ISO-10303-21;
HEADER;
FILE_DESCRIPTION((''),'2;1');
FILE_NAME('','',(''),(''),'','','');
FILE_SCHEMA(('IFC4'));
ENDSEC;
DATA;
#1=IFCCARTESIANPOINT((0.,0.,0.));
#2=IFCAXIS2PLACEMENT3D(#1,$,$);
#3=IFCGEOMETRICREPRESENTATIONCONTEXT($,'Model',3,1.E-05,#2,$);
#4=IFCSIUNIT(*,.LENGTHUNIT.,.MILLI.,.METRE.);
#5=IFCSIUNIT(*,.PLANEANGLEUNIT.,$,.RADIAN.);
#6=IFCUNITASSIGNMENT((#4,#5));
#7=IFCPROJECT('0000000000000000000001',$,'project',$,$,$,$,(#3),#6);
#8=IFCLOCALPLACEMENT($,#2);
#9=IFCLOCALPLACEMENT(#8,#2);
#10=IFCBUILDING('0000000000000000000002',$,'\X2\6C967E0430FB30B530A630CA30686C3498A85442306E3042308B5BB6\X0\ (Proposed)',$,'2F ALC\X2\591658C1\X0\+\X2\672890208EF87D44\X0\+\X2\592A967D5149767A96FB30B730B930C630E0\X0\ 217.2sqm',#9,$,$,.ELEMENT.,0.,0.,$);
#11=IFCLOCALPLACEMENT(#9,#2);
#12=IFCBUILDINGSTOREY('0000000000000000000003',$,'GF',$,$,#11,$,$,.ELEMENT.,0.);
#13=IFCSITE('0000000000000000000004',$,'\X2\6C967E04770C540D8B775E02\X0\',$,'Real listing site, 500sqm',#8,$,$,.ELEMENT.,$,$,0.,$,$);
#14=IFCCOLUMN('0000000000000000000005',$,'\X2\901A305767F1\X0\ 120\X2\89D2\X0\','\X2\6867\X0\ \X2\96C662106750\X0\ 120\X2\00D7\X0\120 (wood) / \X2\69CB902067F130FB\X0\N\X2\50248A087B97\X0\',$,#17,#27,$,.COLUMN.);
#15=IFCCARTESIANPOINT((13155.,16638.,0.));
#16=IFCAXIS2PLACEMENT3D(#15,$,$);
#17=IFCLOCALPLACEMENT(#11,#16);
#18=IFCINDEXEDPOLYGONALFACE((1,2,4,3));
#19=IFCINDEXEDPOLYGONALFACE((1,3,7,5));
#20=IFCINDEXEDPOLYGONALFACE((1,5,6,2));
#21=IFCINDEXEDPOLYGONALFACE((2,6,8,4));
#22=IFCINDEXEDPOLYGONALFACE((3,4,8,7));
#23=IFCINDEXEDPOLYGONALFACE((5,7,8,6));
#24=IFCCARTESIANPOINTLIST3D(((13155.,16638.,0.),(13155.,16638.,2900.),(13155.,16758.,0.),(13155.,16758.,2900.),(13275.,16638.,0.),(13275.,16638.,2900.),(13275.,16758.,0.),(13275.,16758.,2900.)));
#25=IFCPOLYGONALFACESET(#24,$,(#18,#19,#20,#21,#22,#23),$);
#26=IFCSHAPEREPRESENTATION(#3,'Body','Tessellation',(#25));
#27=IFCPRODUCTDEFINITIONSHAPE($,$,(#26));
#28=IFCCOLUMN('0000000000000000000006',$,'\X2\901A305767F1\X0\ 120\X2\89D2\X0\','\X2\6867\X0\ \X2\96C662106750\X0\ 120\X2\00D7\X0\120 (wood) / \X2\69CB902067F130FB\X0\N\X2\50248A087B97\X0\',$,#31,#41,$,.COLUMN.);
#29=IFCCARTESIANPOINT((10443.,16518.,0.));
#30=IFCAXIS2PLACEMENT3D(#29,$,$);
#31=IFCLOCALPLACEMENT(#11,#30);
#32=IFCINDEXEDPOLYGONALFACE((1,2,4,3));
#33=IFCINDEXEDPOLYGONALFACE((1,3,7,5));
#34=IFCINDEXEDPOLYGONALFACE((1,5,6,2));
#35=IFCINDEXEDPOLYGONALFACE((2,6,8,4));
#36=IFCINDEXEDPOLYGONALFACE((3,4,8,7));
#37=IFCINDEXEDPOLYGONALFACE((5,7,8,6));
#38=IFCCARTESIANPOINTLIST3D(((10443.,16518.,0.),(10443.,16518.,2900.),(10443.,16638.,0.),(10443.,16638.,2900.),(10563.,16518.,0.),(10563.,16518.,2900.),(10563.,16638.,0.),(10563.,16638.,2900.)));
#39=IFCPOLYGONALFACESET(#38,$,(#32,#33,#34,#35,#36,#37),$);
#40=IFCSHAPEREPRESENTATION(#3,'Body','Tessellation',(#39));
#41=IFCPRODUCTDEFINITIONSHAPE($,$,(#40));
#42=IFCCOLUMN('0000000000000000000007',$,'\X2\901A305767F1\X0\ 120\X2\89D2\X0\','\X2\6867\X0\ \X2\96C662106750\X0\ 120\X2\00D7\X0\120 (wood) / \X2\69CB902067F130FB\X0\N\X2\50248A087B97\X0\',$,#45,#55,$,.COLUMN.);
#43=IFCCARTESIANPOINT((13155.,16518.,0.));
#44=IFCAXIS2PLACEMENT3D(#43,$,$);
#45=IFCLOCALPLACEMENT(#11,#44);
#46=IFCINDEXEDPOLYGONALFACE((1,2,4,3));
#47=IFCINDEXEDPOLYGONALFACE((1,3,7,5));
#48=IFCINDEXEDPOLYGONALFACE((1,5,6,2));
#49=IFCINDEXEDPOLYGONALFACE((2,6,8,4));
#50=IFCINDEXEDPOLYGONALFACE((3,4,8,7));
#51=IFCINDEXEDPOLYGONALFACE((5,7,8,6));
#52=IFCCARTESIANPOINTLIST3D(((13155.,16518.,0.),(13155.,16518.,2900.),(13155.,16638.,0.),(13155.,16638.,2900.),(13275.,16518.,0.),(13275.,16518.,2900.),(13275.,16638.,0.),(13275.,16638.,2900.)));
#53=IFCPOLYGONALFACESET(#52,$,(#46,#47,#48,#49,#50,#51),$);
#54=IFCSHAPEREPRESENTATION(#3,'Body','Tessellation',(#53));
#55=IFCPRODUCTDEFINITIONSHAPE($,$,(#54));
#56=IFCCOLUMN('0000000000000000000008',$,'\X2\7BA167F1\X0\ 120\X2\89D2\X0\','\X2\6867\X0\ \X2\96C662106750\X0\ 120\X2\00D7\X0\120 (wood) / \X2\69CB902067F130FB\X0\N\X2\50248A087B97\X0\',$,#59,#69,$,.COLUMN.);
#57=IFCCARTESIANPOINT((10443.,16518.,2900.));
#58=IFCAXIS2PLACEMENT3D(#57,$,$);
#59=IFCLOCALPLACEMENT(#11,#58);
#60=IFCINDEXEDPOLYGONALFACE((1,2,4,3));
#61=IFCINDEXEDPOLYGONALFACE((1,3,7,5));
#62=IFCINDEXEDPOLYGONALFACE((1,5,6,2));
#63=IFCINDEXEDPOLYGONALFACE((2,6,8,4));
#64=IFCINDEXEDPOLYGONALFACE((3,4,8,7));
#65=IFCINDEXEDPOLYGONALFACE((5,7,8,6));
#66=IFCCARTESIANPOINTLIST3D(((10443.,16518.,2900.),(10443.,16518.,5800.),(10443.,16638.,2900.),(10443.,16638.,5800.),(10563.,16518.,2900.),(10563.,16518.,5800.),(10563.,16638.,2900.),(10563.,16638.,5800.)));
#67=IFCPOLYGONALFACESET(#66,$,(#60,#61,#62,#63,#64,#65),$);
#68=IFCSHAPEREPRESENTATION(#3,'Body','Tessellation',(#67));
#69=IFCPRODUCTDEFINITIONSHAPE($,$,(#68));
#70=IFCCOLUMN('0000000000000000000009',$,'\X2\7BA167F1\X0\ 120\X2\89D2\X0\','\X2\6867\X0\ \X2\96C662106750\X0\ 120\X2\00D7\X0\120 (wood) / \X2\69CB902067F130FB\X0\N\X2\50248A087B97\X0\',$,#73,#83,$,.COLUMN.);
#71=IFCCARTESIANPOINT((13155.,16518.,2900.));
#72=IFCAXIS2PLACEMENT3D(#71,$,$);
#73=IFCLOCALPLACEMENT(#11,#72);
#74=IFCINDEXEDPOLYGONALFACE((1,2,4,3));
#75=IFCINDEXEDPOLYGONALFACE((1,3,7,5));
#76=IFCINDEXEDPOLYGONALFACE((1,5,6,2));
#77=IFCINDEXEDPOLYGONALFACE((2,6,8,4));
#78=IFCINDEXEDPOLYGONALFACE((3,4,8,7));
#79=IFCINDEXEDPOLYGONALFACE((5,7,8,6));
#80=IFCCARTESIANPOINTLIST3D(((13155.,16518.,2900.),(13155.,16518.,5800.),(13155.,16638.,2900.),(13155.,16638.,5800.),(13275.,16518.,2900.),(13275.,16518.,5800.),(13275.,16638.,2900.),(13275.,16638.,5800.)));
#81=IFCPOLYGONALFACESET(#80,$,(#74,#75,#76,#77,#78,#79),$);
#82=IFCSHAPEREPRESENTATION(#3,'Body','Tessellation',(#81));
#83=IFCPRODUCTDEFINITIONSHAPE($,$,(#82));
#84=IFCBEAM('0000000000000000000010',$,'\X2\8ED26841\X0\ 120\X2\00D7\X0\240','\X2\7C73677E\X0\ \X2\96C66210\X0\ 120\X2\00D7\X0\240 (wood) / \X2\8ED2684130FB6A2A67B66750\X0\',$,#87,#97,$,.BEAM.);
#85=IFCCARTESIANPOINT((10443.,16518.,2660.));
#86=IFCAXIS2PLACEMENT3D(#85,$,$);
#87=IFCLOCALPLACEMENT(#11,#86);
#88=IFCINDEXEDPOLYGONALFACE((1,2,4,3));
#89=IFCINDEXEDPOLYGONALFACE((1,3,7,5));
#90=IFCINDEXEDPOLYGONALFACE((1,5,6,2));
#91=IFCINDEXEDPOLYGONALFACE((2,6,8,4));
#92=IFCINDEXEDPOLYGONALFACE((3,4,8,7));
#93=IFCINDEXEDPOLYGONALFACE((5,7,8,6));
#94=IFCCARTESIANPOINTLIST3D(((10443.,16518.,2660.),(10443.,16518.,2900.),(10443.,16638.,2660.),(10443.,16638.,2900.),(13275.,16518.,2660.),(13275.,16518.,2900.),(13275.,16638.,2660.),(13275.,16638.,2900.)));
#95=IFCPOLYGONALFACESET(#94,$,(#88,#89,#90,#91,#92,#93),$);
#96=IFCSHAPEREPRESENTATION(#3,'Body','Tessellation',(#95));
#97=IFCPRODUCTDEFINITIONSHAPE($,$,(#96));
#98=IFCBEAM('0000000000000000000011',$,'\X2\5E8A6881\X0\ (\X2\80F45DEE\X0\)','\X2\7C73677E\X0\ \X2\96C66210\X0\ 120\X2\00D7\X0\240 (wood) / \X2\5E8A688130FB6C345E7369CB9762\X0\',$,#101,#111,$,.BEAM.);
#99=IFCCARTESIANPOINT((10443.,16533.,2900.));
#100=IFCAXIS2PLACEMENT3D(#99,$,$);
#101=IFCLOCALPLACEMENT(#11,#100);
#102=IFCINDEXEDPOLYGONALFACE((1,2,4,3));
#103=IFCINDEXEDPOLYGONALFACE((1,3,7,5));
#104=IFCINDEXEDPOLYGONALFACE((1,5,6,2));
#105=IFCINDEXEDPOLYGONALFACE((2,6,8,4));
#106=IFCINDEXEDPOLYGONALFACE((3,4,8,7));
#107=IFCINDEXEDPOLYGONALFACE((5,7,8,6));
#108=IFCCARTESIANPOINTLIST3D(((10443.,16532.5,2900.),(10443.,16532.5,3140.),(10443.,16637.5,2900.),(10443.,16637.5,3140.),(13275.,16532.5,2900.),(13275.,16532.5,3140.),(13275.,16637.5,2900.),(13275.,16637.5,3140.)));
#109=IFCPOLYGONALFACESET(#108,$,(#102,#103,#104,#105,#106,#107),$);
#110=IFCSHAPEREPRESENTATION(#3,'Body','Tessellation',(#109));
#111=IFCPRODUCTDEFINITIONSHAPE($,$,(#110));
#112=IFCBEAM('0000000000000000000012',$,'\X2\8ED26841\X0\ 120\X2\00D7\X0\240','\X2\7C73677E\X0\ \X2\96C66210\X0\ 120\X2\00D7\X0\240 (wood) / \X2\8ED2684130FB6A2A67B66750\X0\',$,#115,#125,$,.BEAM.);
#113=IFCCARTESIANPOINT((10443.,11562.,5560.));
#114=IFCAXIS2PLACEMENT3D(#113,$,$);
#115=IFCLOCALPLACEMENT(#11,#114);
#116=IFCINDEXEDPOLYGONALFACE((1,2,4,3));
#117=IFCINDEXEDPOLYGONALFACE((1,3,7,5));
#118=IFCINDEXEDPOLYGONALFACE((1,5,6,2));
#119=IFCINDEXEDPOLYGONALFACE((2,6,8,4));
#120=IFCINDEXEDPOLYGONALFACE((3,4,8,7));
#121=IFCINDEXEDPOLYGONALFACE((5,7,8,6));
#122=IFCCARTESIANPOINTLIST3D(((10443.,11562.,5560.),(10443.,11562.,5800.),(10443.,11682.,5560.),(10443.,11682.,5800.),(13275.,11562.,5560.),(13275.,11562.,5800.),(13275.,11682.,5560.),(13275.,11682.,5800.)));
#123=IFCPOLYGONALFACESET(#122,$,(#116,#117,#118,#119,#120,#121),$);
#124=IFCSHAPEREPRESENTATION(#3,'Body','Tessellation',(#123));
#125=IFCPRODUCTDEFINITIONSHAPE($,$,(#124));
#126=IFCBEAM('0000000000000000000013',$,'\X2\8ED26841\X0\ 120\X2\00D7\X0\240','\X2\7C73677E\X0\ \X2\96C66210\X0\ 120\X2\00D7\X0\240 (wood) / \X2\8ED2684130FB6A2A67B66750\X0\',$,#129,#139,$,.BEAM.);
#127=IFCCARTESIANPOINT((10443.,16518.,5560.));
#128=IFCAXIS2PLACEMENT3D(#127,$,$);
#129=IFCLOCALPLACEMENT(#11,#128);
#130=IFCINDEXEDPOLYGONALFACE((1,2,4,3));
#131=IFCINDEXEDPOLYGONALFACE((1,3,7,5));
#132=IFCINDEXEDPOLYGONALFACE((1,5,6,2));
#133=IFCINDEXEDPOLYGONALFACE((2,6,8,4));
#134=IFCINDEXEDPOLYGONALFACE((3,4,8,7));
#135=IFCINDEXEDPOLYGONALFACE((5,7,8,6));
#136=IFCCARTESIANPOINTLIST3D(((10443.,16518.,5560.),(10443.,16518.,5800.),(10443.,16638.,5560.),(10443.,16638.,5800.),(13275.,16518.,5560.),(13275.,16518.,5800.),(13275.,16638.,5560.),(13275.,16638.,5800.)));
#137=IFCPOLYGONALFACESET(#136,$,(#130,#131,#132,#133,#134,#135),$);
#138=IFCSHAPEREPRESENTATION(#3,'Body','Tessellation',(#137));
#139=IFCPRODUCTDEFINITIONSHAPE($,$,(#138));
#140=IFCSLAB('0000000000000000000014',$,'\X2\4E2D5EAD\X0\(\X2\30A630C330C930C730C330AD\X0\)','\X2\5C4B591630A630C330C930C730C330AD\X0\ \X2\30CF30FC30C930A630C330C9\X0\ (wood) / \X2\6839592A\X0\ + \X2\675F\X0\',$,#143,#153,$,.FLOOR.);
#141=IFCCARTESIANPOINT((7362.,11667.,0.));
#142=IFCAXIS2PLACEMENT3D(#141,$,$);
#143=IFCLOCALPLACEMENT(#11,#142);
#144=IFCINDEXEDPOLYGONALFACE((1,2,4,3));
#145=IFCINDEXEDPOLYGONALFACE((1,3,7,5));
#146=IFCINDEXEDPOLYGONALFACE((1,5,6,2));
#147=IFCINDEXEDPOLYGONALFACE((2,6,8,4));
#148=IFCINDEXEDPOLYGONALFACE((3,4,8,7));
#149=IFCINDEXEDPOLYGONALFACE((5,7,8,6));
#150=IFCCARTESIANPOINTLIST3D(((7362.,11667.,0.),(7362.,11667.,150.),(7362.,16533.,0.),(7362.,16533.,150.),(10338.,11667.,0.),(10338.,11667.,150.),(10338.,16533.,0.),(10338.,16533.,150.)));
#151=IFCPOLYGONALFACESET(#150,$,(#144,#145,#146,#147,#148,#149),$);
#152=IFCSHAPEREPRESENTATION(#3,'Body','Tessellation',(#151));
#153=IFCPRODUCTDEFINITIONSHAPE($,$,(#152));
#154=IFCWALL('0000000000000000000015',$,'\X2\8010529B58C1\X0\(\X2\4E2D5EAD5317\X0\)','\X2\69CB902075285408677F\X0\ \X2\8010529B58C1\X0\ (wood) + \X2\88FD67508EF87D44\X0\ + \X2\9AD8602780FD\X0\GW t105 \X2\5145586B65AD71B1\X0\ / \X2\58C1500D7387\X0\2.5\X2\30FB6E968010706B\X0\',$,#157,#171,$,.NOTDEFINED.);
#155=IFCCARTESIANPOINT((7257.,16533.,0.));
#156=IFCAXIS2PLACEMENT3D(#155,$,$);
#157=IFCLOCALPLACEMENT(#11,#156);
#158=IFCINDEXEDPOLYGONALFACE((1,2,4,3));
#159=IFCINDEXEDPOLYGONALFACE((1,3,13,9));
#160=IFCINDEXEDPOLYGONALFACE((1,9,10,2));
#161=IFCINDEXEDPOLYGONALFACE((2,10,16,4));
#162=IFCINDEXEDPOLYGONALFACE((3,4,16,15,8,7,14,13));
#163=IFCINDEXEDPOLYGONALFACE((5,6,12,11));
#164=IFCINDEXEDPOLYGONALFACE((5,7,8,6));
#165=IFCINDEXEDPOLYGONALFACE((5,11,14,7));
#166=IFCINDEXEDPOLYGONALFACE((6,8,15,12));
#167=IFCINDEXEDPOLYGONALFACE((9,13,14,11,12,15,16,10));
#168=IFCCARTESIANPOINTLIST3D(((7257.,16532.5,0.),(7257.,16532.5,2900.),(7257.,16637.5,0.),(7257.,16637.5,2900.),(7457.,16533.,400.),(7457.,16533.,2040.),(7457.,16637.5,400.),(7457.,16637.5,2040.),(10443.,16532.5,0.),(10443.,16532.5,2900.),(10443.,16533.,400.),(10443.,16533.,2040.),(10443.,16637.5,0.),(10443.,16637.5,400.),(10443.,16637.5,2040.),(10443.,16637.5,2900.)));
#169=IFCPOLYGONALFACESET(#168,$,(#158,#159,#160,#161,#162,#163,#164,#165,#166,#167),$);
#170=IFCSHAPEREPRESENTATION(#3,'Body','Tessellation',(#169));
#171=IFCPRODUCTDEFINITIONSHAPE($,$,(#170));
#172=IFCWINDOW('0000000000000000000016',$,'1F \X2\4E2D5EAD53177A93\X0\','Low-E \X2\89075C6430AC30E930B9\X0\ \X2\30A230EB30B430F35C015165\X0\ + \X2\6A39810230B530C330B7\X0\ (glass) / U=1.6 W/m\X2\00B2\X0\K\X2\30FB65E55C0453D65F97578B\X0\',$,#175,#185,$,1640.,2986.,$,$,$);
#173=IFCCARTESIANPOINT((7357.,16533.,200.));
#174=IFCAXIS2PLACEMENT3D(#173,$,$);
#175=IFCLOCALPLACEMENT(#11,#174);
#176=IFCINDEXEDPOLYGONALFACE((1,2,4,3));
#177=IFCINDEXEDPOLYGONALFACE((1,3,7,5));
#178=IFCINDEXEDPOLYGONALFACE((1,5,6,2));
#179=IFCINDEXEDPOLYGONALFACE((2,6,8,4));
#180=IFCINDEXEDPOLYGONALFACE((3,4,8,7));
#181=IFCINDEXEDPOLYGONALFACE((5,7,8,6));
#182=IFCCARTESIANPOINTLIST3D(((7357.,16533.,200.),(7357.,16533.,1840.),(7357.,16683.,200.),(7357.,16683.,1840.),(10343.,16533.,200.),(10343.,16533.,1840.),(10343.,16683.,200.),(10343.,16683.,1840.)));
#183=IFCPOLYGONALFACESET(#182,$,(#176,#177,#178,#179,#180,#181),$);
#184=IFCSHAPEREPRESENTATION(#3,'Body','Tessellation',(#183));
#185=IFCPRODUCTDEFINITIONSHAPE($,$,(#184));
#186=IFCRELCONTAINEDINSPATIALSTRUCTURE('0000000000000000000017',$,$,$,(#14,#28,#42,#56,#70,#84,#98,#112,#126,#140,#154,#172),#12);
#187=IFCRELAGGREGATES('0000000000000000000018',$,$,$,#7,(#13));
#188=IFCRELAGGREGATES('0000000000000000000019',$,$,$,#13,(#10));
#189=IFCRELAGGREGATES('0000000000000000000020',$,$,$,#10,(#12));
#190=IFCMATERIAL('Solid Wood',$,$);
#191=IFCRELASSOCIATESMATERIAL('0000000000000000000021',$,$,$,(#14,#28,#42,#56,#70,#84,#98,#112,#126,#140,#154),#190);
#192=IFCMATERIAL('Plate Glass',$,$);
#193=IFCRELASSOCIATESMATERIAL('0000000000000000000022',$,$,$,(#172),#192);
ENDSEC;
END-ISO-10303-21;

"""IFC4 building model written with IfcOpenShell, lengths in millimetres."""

from ifc_helpers import new_model, si_unit, frame, frame_2d, origin, place, context, project, spatial, rectangle, extrude, material, element, fill, save


model = new_model("IFC4")

# Units and contexts
model_context = context("Model", 3, precision=1e-05, world=origin())
ifc_project = project(units=[si_unit("LENGTHUNIT", "METRE", prefix="MILLI"), si_unit("PLANEANGLEUNIT", "RADIAN")], contexts=[model_context])

# Site, building, storey
site_placement = place(None, origin())
site = spatial("IfcSite", under=ifc_project, at=site_placement, Name="沖縄県名護市", ObjectType="Real listing site, 500sqm", CompositionType="ELEMENT", RefElevation=0.0)
building_placement = place(site_placement, origin())
building = spatial("IfcBuilding", under=site, at=building_placement, Name="沖縄・サウナと水風呂のある家 (Proposed)", ObjectType="2F ALC外壁+木造軸組+太陽光発電システム 217.2sqm", CompositionType="ELEMENT", ElevationOfRefHeight=0.0, ElevationOfTerrain=0.0)
storey_placement = place(building_placement, origin())
storey = spatial("IfcBuildingStorey", under=building, at=storey_placement, Name="GF", CompositionType="ELEMENT", Elevation=0.0)

# Columns
ifc_material_1 = material(Name="Solid Wood")
column_1_placement = place(storey_placement, frame((13155.0, 16638.0, 0.0)))
element("IfcColumn", 1, at=column_1_placement, inside=storey, material=ifc_material_1, Name="通し柱 120角", Description="桧 集成材 120×120 (wood) / 構造柱・N値計算", PredefinedType="COLUMN", context=model_context, shape_type="SweptSolid", body=[
    extrude(rectangle(XDim=120.0, YDim=120.0, at=frame_2d((60.0, 60.0))), frame((13155.0, 16638.0, 0.0)), (0.0, 0.0, 1.0), 2900.0),
])
column_2_placement = place(storey_placement, frame((10443.0, 16518.0, 0.0)))
element("IfcColumn", 2, at=column_2_placement, inside=storey, material=ifc_material_1, Name="通し柱 120角", Description="桧 集成材 120×120 (wood) / 構造柱・N値計算", PredefinedType="COLUMN", context=model_context, shape_type="SweptSolid", body=[
    extrude(rectangle(XDim=120.0, YDim=120.0, at=frame_2d((60.0, 60.0))), frame((10443.0, 16518.0, 0.0)), (0.0, 0.0, 1.0), 2900.0),
])
column_3_placement = place(storey_placement, frame((13155.0, 16518.0, 0.0)))
element("IfcColumn", 3, at=column_3_placement, inside=storey, material=ifc_material_1, Name="通し柱 120角", Description="桧 集成材 120×120 (wood) / 構造柱・N値計算", PredefinedType="COLUMN", context=model_context, shape_type="SweptSolid", body=[
    extrude(rectangle(XDim=120.0, YDim=120.0, at=frame_2d((60.0, 60.0))), frame((13155.0, 16518.0, 0.0)), (0.0, 0.0, 1.0), 2900.0),
])
column_4_placement = place(storey_placement, frame((10443.0, 16518.0, 2900.0)))
element("IfcColumn", 4, at=column_4_placement, inside=storey, material=ifc_material_1, Name="管柱 120角", Description="桧 集成材 120×120 (wood) / 構造柱・N値計算", PredefinedType="COLUMN", context=model_context, shape_type="SweptSolid", body=[
    extrude(rectangle(XDim=120.0, YDim=120.0, at=frame_2d((60.0, 60.0))), frame((10443.0, 16518.0, 2900.0)), (0.0, 0.0, 1.0), 2900.0),
])
column_5_placement = place(storey_placement, frame((13155.0, 16518.0, 2900.0)))
element("IfcColumn", 5, at=column_5_placement, inside=storey, material=ifc_material_1, Name="管柱 120角", Description="桧 集成材 120×120 (wood) / 構造柱・N値計算", PredefinedType="COLUMN", context=model_context, shape_type="SweptSolid", body=[
    extrude(rectangle(XDim=120.0, YDim=120.0, at=frame_2d((60.0, 60.0))), frame((13155.0, 16518.0, 2900.0)), (0.0, 0.0, 1.0), 2900.0),
])

# Beams
beam_1_placement = place(storey_placement, frame((10443.0, 16518.0, 2660.0)))
element("IfcBeam", 6, at=beam_1_placement, inside=storey, material=ifc_material_1, Name="軒桁 120×240", Description="米松 集成 120×240 (wood) / 軒桁・横架材", PredefinedType="BEAM", context=model_context, shape_type="SweptSolid", body=[
    extrude(rectangle(XDim=2832.0, YDim=120.0, at=frame_2d((1416.0, 60.0))), frame((10443.0, 16518.0, 2660.0)), (0.0, 0.0, 1.0), 240.0),
])
beam_2_placement = place(storey_placement, frame((10443.0, 16533.0, 2900.0)))
element("IfcBeam", 7, at=beam_2_placement, inside=storey, material=ifc_material_1, Name="床梁 (胴差)", Description="米松 集成 120×240 (wood) / 床梁・水平構面", PredefinedType="BEAM", context=model_context, shape_type="SweptSolid", body=[
    extrude(rectangle(XDim=2832.0, YDim=105.0, at=frame_2d((1416.0, 52.0))), frame((10443.0, 16533.0, 2900.0)), (0.0, 0.0, 1.0), 240.0),
])
beam_3_placement = place(storey_placement, frame((10443.0, 11562.0, 5560.0)))
element("IfcBeam", 8, at=beam_3_placement, inside=storey, material=ifc_material_1, Name="軒桁 120×240", Description="米松 集成 120×240 (wood) / 軒桁・横架材", PredefinedType="BEAM", context=model_context, shape_type="SweptSolid", body=[
    extrude(rectangle(XDim=2832.0, YDim=120.0, at=frame_2d((1416.0, 60.0))), frame((10443.0, 11562.0, 5560.0)), (0.0, 0.0, 1.0), 240.0),
])
beam_4_placement = place(storey_placement, frame((10443.0, 16518.0, 5560.0)))
element("IfcBeam", 9, at=beam_4_placement, inside=storey, material=ifc_material_1, Name="軒桁 120×240", Description="米松 集成 120×240 (wood) / 軒桁・横架材", PredefinedType="BEAM", context=model_context, shape_type="SweptSolid", body=[
    extrude(rectangle(XDim=2832.0, YDim=120.0, at=frame_2d((1416.0, 60.0))), frame((10443.0, 16518.0, 5560.0)), (0.0, 0.0, 1.0), 240.0),
])

# Slab
slab_placement = place(storey_placement, frame((7362.0, 11667.0, 0.0)))
element("IfcSlab", 10, at=slab_placement, inside=storey, material=ifc_material_1, Name="中庭(ウッドデッキ)", Description="屋外ウッドデッキ ハードウッド (wood) / 根太 + 束", PredefinedType="FLOOR", context=model_context, shape_type="SweptSolid", body=[
    extrude(rectangle(XDim=2976.0, YDim=4866.0, at=frame_2d((1488.0, 2433.0))), frame((7362.0, 11667.0, 0.0)), (0.0, 0.0, 1.0), 150.0),
])

# Wall, opening, window
wall_1_placement = place(storey_placement, frame((7257.0, 16533.0, 0.0)))
wall_1 = element("IfcWall", 11, at=wall_1_placement, inside=storey, material=ifc_material_1, Name="耐力壁(中庭北)", Description="構造用合板 耐力壁 (wood) + 製材軸組 + 高性能GW t105 充填断熱 / 壁倍率2.5・準耐火", PredefinedType="NOTDEFINED", context=model_context, shape_type="SweptSolid", body=[
    extrude(rectangle(XDim=3186.0, YDim=105.0, at=frame_2d((1593.0, 52.0))), frame((7257.0, 16533.0, 0.0)), (0.0, 0.0, 1.0), 2900.0),
])
opening_1_placement = place(storey_placement, frame((7357.0, 16533.0, 200.0)))
opening_1 = element("IfcOpeningElement", 12, at=opening_1_placement, cuts=wall_1, PredefinedType="NOTDEFINED", context=model_context, shape_type="SweptSolid", body=[
    extrude(rectangle(XDim=2986.0, YDim=150.0, at=frame_2d((1493.0, 75.0))), frame((7357.0, 16533.0, 200.0)), (0.0, 0.0, 1.0), 1640.0),
])
ifc_material_2 = material(Name="Plate Glass")
window_1_placement = place(storey_placement, frame((7357.0, 16533.0, 200.0)))
window_1 = element("IfcWindow", 13, at=window_1_placement, inside=storey, material=ifc_material_2, Name="1F 中庭北窓", Description="Low-E 複層ガラス アルゴン封入 + 樹脂サッシ (glass) / U=1.6 W/m²K・日射取得型", OverallHeight=1640.0, OverallWidth=2986.0, context=model_context, shape_type="SweptSolid", body=[
    extrude(rectangle(XDim=2986.0, YDim=150.0, at=frame_2d((1493.0, 75.0))), frame((7357.0, 16533.0, 200.0)), (0.0, 0.0, 1.0), 1640.0),
])
fill(opening_1, window_1)

save(model, "model.ifc")
